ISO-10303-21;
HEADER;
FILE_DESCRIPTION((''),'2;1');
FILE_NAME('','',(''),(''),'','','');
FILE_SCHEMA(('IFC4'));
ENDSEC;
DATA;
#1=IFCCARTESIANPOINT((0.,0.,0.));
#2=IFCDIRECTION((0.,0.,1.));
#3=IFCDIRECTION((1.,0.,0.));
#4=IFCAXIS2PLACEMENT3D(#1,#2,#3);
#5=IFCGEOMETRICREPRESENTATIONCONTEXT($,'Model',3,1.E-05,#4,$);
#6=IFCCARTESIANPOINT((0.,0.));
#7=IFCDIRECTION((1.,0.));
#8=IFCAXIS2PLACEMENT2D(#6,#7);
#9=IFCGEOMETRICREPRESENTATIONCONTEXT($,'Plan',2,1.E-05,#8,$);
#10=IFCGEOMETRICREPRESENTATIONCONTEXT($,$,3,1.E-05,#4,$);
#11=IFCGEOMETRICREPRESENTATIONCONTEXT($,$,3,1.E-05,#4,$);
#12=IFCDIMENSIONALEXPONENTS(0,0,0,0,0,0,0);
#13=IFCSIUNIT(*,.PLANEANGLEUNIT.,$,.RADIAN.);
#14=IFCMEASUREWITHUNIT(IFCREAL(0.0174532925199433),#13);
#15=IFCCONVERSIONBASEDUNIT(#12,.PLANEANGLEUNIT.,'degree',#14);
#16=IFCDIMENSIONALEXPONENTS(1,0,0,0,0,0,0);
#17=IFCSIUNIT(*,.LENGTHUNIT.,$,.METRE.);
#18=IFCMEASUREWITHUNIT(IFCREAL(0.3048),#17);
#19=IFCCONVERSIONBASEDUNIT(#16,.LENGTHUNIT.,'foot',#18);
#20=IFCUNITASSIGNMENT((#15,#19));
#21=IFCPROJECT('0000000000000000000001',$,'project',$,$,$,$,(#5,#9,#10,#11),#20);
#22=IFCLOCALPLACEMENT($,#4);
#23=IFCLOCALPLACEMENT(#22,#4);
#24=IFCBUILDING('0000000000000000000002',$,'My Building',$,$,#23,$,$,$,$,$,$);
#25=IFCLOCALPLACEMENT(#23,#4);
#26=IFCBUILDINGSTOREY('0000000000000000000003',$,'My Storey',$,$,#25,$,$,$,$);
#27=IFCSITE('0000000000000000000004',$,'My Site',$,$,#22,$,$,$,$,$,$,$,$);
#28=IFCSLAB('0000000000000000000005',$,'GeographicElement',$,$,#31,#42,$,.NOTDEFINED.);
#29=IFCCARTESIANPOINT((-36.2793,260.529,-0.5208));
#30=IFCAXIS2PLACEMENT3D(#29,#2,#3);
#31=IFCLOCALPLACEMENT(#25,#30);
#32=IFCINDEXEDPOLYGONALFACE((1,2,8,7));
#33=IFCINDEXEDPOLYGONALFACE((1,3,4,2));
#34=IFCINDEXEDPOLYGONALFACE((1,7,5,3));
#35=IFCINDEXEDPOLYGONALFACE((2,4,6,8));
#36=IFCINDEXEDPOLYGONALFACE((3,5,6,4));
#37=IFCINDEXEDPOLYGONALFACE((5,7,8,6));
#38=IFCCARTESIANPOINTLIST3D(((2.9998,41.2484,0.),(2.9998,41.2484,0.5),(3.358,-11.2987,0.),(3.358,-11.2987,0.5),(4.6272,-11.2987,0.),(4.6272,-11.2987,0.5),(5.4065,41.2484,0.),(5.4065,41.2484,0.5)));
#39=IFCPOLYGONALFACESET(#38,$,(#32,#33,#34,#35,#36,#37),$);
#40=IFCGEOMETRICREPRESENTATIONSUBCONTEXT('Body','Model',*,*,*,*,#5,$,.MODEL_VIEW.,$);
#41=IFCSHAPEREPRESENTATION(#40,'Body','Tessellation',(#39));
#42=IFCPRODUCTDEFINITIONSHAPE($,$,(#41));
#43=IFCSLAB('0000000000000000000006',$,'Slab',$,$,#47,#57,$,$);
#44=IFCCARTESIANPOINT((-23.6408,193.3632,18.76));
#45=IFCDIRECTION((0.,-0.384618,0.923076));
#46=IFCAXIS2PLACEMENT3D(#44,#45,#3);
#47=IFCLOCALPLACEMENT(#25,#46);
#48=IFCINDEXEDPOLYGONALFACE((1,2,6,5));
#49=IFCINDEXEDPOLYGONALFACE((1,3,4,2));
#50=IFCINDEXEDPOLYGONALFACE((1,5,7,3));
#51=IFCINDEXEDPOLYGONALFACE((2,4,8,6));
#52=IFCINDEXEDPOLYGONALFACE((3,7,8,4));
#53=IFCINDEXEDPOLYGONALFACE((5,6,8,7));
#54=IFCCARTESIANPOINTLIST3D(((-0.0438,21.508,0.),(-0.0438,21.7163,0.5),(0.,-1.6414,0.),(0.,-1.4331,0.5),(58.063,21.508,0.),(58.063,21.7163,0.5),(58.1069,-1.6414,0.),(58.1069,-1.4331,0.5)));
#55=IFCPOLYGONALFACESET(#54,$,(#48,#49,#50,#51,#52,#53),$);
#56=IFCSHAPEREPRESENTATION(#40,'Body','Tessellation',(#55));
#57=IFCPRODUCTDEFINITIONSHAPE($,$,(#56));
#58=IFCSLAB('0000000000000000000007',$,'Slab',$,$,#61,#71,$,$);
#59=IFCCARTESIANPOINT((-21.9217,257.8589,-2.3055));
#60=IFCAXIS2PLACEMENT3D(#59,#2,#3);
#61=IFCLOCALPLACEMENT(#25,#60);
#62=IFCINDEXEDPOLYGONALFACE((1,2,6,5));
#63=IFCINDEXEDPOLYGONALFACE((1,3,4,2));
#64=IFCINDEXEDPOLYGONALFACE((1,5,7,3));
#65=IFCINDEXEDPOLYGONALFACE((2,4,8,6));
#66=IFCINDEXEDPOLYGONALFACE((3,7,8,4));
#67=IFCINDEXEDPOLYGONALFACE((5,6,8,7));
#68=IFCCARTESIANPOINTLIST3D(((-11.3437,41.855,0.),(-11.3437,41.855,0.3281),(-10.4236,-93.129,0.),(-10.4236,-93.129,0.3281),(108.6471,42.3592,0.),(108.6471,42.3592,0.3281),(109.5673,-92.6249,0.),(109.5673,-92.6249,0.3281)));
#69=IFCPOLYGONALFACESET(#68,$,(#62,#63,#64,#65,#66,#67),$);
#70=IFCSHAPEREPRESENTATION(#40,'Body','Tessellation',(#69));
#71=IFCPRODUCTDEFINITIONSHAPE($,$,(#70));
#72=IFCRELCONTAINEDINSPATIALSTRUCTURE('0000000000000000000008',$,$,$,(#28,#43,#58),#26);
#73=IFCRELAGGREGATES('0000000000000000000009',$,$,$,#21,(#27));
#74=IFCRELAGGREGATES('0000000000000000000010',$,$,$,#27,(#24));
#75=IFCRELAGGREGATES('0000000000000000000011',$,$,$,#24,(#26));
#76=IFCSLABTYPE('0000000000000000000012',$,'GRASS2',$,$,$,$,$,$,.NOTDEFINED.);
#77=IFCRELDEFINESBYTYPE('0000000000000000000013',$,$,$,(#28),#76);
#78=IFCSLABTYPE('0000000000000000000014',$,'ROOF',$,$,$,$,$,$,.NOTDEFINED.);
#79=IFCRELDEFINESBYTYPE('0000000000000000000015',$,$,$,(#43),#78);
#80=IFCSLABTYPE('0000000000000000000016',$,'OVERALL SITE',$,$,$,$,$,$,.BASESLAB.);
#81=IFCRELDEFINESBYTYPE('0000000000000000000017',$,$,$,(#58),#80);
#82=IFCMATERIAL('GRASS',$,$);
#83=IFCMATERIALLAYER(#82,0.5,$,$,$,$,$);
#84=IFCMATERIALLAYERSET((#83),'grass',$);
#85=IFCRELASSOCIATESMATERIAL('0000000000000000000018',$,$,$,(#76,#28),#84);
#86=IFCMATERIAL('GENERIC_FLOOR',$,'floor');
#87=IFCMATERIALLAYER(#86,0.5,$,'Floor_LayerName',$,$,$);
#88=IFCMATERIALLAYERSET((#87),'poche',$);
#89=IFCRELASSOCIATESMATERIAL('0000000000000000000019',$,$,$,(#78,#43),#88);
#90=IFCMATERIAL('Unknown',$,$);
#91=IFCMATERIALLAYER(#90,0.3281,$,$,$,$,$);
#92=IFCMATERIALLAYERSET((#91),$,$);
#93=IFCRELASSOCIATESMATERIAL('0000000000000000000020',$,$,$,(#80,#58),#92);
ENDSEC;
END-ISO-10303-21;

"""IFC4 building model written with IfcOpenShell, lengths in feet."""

from ifc_helpers import new_model, entity, si_unit, converted_unit, frame, origin_with_axes, origin_2d_with_axis, place, context, subcontext, project, spatial, line, indexed_curve, outline, extrude, material, layer, layer_set, layer_usage, type_object, element, save


model = new_model("IFC4")

# Units and contexts
model_context = context("Model", 3, precision=1e-05, world=origin_with_axes())
plan_context = context("Plan", 2, precision=1e-05, world=origin_2d_with_axis())
context_of_model_1 = context(None, 3, precision=1e-05, world=origin_with_axes())
context_of_model_2 = context(None, 3, precision=1e-05, world=origin_with_axes())
body_context = subcontext(model_context, "Body", "Model", "MODEL_VIEW")
ifc_project = project(units=[converted_unit("PLANEANGLEUNIT", "degree", entity("IfcReal", 0.0174532925199433), si_unit("PLANEANGLEUNIT", "RADIAN"), dimensions=[0, 0, 0, 0, 0, 0, 0]), converted_unit("LENGTHUNIT", "foot", entity("IfcReal", 0.3048), si_unit("LENGTHUNIT", "METRE"), dimensions=[1, 0, 0, 0, 0, 0, 0])], contexts=[model_context, plan_context, context_of_model_1, context_of_model_2])

# Site, building, storey
site_placement = place(None, origin_with_axes())
site = spatial("IfcSite", under=ifc_project, at=site_placement, Name="My Site")
building_placement = place(site_placement, origin_with_axes())
building = spatial("IfcBuilding", under=site, at=building_placement, Name="My Building")
storey_placement = place(building_placement, origin_with_axes())
storey = spatial("IfcBuildingStorey", under=building, at=storey_placement, Name="My Storey")

# Slabs
ifc_material_1 = material(Name="GRASS")
ifc_layer_1 = layer(ifc_material_1, 0.5)
ifc_layer_set_1 = layer_set([ifc_layer_1], Name="grass")
ifc_layer_usage_1 = layer_usage(ifc_layer_set_1, "AXIS3", "POSITIVE", 0.0)
slab_type_1 = type_object("IfcSlabType", Name="GRASS2", PredefinedType="NOTDEFINED", material=ifc_layer_set_1)
slab_1_placement = place(storey_placement, frame((-36.2793, 260.529, -0.5208), z_axis=(0.0, 0.0, 1.0), x_axis=(1.0, 0.0, 0.0)))
element("IfcSlab", 1, at=slab_1_placement, inside=storey, type_object=slab_type_1, material=ifc_layer_usage_1, Name="GeographicElement", PredefinedType="NOTDEFINED", context=body_context, shape_type="SweptSolid", body=[
    extrude(outline(indexed_curve([(4.6272, -11.2987), (3.358, -11.2987), (2.9998, 41.2484), (5.4065, 41.2484)], segments=[line(4, 1), line(1, 2), line(2, 3), line(3, 4)], self_intersect=False)), None, (0.0, 0.0, 1.0), 0.5),
])
ifc_material_2 = material(Name="GENERIC_FLOOR", Category="floor")
ifc_layer_2 = layer(ifc_material_2, 0.5, Name="Floor_LayerName")
ifc_layer_set_2 = layer_set([ifc_layer_2], Name="poche")
ifc_layer_usage_2 = layer_usage(ifc_layer_set_2, "AXIS3", "POSITIVE", 0.0)
slab_type_2 = type_object("IfcSlabType", Name="ROOF", PredefinedType="NOTDEFINED", material=ifc_layer_set_2)
slab_2_placement = place(storey_placement, frame((-23.6408, 193.3632, 18.76), z_axis=(0.0, -0.384618, 0.923076), x_axis=(1.0, 0.0, 0.0)))
element("IfcSlab", 2, at=slab_2_placement, inside=storey, type_object=slab_type_2, material=ifc_layer_usage_2, Name="Slab", context=body_context, shape_type="SweptSolid", body=[
    extrude(outline(indexed_curve([(0.0, -1.6414), (-0.0438, 21.508), (58.063, 21.508), (58.1069, -1.6414)], segments=[line(3, 2), line(2, 1), line(1, 4), line(4, 3)], self_intersect=False)), None, (0.0, 0.384618, 0.923076), 0.5417),
])
ifc_material_3 = material(Name="Unknown")
ifc_layer_3 = layer(ifc_material_3, 0.3281)
ifc_layer_set_3 = layer_set([ifc_layer_3])
ifc_layer_usage_3 = layer_usage(ifc_layer_set_3, "AXIS3", "POSITIVE", 0.0)
slab_type_3 = type_object("IfcSlabType", Name="OVERALL SITE", PredefinedType="BASESLAB", material=ifc_layer_set_3)
slab_3_placement = place(storey_placement, frame((-21.9217, 257.8589, -2.3055), z_axis=(0.0, 0.0, 1.0), x_axis=(1.0, 0.0, 0.0)))
element("IfcSlab", 3, at=slab_3_placement, inside=storey, type_object=slab_type_3, material=ifc_layer_usage_3, Name="Slab", context=body_context, shape_type="SweptSolid", body=[
    extrude(outline(indexed_curve([(-11.3437, 41.855), (108.6471, 42.3592), (109.5673, -92.6249), (-10.4236, -93.129)], segments=[line(3, 2), line(2, 1), line(1, 4), line(4, 3)], self_intersect=False)), None, (0.0, 0.0, 1.0), 0.3281),
])

save(model, "model.ifc")
